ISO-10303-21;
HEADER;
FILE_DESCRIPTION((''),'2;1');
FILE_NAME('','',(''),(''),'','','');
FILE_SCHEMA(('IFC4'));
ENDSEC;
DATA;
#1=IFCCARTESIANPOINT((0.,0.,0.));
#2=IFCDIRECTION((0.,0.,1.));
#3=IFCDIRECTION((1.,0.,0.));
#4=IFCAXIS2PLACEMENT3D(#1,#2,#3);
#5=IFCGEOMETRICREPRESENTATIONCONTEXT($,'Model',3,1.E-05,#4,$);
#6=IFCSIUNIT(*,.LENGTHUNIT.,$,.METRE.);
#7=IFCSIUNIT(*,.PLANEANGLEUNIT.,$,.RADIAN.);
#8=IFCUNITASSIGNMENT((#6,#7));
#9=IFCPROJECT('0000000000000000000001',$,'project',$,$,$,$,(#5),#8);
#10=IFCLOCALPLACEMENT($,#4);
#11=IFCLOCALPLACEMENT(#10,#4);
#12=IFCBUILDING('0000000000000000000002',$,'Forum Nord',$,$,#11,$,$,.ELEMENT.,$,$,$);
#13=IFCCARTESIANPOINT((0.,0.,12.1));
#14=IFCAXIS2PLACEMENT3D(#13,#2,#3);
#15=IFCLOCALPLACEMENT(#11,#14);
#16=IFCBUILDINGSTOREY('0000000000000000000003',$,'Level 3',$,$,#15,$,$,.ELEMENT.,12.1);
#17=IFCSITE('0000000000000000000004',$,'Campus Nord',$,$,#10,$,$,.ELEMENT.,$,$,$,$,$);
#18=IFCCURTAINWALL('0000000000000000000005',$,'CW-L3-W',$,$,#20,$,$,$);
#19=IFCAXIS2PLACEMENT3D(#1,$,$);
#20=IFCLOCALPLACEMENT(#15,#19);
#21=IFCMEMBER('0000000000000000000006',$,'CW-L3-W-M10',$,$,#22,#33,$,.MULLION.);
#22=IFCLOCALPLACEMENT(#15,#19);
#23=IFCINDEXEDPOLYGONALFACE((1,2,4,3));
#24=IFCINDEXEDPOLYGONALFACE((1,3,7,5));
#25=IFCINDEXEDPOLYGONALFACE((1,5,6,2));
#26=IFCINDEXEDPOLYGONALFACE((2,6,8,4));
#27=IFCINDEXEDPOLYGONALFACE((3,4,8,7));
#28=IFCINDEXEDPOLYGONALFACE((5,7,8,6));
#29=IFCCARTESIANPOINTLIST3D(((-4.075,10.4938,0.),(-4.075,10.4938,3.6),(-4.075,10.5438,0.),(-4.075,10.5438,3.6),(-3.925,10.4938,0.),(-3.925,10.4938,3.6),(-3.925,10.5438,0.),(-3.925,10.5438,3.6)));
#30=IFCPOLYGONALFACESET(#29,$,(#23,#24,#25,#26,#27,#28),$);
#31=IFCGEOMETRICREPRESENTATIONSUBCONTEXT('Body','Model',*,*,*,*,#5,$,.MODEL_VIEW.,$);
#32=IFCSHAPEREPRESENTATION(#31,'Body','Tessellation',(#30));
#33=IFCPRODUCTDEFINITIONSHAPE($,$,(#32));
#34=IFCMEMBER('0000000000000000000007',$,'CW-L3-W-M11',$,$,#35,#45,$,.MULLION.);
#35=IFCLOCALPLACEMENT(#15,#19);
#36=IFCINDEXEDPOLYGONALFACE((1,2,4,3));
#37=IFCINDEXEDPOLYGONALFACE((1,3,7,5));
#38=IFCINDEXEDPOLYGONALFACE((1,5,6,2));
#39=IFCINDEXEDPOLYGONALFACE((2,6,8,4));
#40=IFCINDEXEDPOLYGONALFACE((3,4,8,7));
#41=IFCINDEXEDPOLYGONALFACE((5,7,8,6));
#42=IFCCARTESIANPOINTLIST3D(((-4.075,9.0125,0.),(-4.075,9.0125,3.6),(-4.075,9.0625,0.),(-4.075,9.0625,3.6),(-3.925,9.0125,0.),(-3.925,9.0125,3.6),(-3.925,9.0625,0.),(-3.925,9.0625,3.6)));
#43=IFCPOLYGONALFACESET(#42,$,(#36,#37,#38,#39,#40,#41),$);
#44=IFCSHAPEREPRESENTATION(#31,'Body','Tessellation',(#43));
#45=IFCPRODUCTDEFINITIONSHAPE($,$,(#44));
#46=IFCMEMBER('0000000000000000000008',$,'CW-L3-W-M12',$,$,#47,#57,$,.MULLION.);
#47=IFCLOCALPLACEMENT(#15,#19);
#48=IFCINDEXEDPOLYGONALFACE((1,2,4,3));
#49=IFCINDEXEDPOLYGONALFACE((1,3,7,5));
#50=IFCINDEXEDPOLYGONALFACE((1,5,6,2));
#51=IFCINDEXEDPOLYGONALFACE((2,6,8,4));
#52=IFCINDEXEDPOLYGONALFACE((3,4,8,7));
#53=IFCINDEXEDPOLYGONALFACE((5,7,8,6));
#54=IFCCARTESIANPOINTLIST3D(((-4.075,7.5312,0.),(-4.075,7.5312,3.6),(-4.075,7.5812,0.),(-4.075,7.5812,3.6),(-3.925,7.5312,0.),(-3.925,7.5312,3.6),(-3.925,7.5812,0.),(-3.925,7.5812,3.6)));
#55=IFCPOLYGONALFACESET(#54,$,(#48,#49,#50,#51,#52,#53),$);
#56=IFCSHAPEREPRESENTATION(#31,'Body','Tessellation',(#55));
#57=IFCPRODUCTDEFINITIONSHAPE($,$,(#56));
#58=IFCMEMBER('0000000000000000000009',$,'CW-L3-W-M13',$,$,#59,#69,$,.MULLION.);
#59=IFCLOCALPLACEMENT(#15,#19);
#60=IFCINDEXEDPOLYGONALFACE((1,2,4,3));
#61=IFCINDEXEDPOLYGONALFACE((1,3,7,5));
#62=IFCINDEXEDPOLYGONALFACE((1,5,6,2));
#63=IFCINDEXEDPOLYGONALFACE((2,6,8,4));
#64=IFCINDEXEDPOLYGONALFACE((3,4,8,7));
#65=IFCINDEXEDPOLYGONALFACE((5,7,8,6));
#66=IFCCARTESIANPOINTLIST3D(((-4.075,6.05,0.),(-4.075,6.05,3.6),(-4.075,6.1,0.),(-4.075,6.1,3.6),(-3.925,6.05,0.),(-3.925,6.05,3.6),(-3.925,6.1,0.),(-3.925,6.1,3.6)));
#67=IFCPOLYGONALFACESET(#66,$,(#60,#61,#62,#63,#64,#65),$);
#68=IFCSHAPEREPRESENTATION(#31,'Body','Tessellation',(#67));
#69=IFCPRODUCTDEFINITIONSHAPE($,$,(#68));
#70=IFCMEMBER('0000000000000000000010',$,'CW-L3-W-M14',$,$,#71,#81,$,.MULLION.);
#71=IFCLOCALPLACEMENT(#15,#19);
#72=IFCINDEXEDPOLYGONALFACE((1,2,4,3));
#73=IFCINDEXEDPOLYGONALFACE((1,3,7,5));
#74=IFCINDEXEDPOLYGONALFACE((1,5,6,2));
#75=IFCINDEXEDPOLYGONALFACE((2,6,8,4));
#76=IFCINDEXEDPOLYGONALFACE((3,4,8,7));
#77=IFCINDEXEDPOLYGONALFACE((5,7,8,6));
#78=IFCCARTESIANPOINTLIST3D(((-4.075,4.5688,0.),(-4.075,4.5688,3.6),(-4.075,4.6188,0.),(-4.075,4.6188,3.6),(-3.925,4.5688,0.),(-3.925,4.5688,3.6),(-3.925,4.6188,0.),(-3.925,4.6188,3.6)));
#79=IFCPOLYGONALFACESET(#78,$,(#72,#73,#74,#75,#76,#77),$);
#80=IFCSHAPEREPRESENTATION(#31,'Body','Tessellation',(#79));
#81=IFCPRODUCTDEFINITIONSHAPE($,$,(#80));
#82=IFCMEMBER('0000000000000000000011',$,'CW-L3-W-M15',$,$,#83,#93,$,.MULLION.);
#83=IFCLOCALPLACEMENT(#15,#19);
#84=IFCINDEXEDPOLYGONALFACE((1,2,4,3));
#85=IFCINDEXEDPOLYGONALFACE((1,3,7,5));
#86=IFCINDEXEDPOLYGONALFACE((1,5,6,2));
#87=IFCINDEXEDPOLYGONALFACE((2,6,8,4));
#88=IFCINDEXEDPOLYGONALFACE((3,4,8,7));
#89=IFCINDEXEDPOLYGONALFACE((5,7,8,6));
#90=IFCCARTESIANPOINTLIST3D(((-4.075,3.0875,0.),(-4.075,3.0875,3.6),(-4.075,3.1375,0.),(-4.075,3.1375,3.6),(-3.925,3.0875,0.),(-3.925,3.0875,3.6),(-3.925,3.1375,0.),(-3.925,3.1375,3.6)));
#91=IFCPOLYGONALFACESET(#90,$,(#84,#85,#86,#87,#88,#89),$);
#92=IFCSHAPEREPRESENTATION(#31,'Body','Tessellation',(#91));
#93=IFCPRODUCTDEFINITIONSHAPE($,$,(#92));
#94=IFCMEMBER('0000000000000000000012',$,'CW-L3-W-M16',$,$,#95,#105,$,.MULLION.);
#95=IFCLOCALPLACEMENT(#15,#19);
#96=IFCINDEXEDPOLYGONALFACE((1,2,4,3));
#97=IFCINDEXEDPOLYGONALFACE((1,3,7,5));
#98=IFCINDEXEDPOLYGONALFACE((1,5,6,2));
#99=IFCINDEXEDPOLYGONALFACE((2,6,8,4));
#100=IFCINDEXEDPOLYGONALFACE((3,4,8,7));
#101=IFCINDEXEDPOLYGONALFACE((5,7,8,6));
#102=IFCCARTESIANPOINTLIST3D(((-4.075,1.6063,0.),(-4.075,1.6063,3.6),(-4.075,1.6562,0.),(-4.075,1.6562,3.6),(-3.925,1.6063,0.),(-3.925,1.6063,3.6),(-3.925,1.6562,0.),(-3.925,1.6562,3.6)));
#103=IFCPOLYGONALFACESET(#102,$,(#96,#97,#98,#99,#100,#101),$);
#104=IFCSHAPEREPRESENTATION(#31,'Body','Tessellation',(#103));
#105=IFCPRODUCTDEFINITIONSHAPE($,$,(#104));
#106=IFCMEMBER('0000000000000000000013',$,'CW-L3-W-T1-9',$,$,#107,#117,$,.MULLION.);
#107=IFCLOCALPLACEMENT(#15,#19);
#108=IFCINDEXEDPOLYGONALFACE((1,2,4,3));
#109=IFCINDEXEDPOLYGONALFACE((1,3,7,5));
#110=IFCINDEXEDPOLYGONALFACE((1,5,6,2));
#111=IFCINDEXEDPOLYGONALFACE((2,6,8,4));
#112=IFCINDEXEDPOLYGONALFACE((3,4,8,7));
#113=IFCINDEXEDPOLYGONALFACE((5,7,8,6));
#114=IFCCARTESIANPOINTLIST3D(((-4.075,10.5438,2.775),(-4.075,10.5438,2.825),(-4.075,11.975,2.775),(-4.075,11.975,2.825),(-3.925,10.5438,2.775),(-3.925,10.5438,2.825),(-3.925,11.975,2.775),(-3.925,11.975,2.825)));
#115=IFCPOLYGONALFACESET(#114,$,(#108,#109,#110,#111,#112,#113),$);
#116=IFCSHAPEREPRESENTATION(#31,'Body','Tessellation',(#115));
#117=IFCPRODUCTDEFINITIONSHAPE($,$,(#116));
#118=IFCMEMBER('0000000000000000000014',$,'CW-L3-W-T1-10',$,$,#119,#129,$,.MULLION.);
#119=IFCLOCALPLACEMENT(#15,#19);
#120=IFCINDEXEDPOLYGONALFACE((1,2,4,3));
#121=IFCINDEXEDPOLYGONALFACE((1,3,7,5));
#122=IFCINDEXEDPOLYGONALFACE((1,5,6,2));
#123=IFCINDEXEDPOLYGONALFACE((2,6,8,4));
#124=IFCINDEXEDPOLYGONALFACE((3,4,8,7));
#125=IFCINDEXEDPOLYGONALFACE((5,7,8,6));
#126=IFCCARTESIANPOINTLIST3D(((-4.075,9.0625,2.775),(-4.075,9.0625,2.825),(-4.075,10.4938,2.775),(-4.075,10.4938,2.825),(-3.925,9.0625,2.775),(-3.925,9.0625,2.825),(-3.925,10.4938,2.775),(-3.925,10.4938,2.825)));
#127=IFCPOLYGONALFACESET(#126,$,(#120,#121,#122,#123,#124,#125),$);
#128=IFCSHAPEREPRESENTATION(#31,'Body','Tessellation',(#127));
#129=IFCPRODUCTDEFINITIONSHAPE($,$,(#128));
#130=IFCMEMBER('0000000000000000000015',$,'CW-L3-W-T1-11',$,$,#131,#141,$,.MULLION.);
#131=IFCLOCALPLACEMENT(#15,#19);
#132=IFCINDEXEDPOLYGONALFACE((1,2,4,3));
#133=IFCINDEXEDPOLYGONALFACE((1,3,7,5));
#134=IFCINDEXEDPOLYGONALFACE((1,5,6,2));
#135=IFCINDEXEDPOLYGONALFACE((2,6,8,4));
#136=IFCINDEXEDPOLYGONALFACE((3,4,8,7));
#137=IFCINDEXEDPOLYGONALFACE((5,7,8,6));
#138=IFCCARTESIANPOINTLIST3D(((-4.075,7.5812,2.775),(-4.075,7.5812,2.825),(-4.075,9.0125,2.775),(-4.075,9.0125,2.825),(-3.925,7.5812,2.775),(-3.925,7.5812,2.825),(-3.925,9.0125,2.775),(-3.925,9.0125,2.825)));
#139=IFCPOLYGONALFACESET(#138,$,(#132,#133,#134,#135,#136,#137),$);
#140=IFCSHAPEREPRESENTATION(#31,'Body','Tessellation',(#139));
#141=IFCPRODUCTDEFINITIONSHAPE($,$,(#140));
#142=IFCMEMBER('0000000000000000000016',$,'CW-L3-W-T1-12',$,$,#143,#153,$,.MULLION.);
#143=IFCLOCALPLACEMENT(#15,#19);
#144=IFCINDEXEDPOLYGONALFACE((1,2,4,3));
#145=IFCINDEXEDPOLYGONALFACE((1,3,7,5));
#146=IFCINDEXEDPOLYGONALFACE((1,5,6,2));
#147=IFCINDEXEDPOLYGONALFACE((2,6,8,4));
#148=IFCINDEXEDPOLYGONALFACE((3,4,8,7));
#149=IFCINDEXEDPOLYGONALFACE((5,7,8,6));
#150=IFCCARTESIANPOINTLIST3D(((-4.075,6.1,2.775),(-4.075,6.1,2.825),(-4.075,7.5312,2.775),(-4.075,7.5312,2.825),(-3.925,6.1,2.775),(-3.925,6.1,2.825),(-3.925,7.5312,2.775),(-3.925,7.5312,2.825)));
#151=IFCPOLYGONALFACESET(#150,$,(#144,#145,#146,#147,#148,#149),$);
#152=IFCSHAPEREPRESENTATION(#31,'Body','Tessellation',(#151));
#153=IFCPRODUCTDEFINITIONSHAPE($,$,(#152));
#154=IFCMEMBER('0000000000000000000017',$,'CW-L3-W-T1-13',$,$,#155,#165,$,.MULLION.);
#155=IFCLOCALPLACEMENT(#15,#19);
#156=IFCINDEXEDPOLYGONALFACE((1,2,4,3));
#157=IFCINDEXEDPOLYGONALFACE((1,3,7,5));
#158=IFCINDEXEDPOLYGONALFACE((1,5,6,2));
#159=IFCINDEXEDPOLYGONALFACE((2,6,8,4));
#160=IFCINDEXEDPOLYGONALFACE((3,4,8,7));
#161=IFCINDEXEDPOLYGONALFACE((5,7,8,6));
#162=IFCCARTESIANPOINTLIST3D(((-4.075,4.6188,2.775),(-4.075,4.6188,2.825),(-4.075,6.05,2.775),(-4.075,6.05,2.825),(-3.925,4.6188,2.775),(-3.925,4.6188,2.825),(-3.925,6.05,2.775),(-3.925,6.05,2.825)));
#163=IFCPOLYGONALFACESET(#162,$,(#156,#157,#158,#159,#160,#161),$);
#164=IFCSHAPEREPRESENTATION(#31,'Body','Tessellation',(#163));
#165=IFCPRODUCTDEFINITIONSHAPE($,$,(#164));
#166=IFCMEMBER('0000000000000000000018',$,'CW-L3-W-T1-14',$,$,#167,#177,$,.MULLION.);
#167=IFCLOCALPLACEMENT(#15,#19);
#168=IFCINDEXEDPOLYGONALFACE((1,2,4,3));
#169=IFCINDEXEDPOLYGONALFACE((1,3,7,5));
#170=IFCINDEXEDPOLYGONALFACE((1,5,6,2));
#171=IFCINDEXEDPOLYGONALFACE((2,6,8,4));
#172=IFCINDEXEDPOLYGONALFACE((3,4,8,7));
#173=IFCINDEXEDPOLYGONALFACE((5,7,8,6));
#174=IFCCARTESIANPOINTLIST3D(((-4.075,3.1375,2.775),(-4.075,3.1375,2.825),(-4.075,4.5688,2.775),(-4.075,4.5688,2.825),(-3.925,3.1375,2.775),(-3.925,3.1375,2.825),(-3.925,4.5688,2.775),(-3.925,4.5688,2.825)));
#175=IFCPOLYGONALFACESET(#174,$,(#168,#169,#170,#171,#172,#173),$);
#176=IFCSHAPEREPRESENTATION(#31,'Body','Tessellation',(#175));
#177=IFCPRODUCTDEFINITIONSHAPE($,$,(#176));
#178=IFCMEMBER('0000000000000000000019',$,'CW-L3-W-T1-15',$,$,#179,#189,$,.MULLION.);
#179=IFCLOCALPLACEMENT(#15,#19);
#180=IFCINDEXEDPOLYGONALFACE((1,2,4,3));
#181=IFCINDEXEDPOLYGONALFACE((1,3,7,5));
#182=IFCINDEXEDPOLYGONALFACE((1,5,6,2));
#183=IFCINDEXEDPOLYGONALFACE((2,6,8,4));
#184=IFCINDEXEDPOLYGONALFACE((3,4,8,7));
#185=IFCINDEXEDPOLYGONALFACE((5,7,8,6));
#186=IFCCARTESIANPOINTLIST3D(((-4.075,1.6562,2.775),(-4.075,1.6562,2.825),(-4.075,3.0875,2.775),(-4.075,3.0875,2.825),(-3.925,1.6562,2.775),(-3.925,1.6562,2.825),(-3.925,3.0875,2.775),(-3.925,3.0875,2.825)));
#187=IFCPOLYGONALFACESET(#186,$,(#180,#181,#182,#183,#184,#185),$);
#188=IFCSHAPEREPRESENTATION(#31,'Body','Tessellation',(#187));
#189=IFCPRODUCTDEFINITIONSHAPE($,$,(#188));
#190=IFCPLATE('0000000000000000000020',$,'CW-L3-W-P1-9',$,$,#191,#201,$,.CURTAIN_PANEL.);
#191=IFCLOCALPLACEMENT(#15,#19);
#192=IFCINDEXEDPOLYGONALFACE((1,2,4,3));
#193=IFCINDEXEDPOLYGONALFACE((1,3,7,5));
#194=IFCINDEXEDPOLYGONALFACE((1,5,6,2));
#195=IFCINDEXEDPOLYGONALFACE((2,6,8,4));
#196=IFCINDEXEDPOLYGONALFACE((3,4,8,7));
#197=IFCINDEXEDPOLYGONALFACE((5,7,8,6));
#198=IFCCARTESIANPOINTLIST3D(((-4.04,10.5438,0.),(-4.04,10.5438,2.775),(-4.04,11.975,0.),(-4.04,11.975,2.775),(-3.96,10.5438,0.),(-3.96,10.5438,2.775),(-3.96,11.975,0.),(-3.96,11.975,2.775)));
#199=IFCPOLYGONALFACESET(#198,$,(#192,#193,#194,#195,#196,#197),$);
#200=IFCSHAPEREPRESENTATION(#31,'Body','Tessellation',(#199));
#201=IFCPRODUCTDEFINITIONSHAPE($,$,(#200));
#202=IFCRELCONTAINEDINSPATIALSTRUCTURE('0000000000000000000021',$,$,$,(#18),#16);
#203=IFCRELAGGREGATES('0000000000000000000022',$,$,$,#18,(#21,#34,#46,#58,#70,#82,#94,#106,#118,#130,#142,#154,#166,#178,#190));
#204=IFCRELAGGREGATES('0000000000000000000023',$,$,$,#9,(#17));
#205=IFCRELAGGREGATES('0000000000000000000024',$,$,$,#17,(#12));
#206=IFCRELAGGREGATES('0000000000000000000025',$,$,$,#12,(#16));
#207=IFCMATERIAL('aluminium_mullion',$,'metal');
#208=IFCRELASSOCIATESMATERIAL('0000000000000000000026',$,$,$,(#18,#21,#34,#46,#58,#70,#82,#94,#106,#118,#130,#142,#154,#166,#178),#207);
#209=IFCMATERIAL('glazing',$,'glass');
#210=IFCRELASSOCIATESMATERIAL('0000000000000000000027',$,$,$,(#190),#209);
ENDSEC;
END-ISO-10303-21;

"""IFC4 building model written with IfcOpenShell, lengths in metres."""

from ifc_helpers import new_model, si_unit, frame, frame_2d, origin_with_axes, origin_2d_with_axis, place, context, subcontext, project, spatial, rectangle, extrude, material, element, aggregate, save


model = new_model("IFC4")

# Units and contexts
model_context = context("Model", 3, precision=1e-05, world=origin_with_axes())
body_context = subcontext(model_context, "Body", "Model", "MODEL_VIEW")
ifc_project = project(units=[si_unit("LENGTHUNIT", "METRE"), si_unit("PLANEANGLEUNIT", "RADIAN")], contexts=[model_context])

# Site, building, storey
site_placement = place(None, origin_with_axes())
site = spatial("IfcSite", under=ifc_project, at=site_placement, Name="Campus Nord", CompositionType="ELEMENT")
building_placement = place(site_placement, origin_with_axes())
building = spatial("IfcBuilding", under=site, at=building_placement, Name="Forum Nord", CompositionType="ELEMENT")
storey_placement = place(building_placement, frame((0.0, 0.0, 12.1), z_axis=(0.0, 0.0, 1.0), x_axis=(1.0, 0.0, 0.0)))
storey = spatial("IfcBuildingStorey", under=building, at=storey_placement, Name="Level 3", CompositionType="ELEMENT", Elevation=12.1)

# Curtain wall, members, plate
ifc_material_1 = material(Name="aluminium_mullion", Category="metal")
curtain_wall_placement = place(storey_placement, origin_with_axes())
curtain_wall = element("IfcCurtainWall", 1, at=curtain_wall_placement, inside=storey, material=ifc_material_1, Name="CW-L3-W")
member_1_placement = place(storey_placement, frame((-4.0, 10.5188, 0.0), z_axis=(0.0, 0.0, 1.0), x_axis=(0.0, -1.0, 0.0)))
member_1 = element("IfcMember", 2, at=member_1_placement, material=ifc_material_1, Name="CW-L3-W-M10", PredefinedType="MULLION", context=body_context, shape_type="SweptSolid", body=[
    extrude(rectangle(XDim=0.05, YDim=0.15, at=origin_2d_with_axis()), origin_with_axes(), (0.0, 0.0, 1.0), 3.6),
])
member_2_placement = place(storey_placement, frame((-4.0, 9.0375, 0.0), z_axis=(0.0, 0.0, 1.0), x_axis=(0.0, -1.0, 0.0)))
member_2 = element("IfcMember", 3, at=member_2_placement, material=ifc_material_1, Name="CW-L3-W-M11", PredefinedType="MULLION", context=body_context, shape_type="SweptSolid", body=[
    extrude(rectangle(XDim=0.05, YDim=0.15, at=origin_2d_with_axis()), origin_with_axes(), (0.0, 0.0, 1.0), 3.6),
])
member_3_placement = place(storey_placement, frame((-4.0, 7.5563, 0.0), z_axis=(0.0, 0.0, 1.0), x_axis=(0.0, -1.0, 0.0)))
member_3 = element("IfcMember", 4, at=member_3_placement, material=ifc_material_1, Name="CW-L3-W-M12", PredefinedType="MULLION", context=body_context, shape_type="SweptSolid", body=[
    extrude(rectangle(XDim=0.05, YDim=0.15, at=origin_2d_with_axis()), origin_with_axes(), (0.0, 0.0, 1.0), 3.6),
])
member_4_placement = place(storey_placement, frame((-4.0, 6.075, 0.0), z_axis=(0.0, 0.0, 1.0), x_axis=(0.0, -1.0, 0.0)))
member_4 = element("IfcMember", 5, at=member_4_placement, material=ifc_material_1, Name="CW-L3-W-M13", PredefinedType="MULLION", context=body_context, shape_type="SweptSolid", body=[
    extrude(rectangle(XDim=0.05, YDim=0.15, at=origin_2d_with_axis()), origin_with_axes(), (0.0, 0.0, 1.0), 3.6),
])
member_5_placement = place(storey_placement, frame((-4.0, 4.5938, 0.0), z_axis=(0.0, 0.0, 1.0), x_axis=(0.0, -1.0, 0.0)))
member_5 = element("IfcMember", 6, at=member_5_placement, material=ifc_material_1, Name="CW-L3-W-M14", PredefinedType="MULLION", context=body_context, shape_type="SweptSolid", body=[
    extrude(rectangle(XDim=0.05, YDim=0.15, at=origin_2d_with_axis()), origin_with_axes(), (0.0, 0.0, 1.0), 3.6),
])
member_6_placement = place(storey_placement, frame((-4.0, 3.1125, 0.0), z_axis=(0.0, 0.0, 1.0), x_axis=(0.0, -1.0, 0.0)))
member_6 = element("IfcMember", 7, at=member_6_placement, material=ifc_material_1, Name="CW-L3-W-M15", PredefinedType="MULLION", context=body_context, shape_type="SweptSolid", body=[
    extrude(rectangle(XDim=0.05, YDim=0.15, at=origin_2d_with_axis()), origin_with_axes(), (0.0, 0.0, 1.0), 3.6),
])
member_7_placement = place(storey_placement, frame((-4.0, 1.6313, 0.0), z_axis=(0.0, 0.0, 1.0), x_axis=(0.0, -1.0, 0.0)))
member_7 = element("IfcMember", 8, at=member_7_placement, material=ifc_material_1, Name="CW-L3-W-M16", PredefinedType="MULLION", context=body_context, shape_type="SweptSolid", body=[
    extrude(rectangle(XDim=0.05, YDim=0.15, at=origin_2d_with_axis()), origin_with_axes(), (0.0, 0.0, 1.0), 3.6),
])
member_8_placement = place(storey_placement, frame((-4.0, 11.975, 2.8), z_axis=(0.0, -1.0, 0.0), x_axis=(1.0, 0.0, 0.0)))
member_8 = element("IfcMember", 9, at=member_8_placement, material=ifc_material_1, Name="CW-L3-W-T1-9", PredefinedType="MULLION", context=body_context, shape_type="SweptSolid", body=[
    extrude(rectangle(XDim=0.15, YDim=0.05, at=origin_2d_with_axis()), origin_with_axes(), (0.0, 0.0, 1.0), 1.4312),
])
member_9_placement = place(storey_placement, frame((-4.0, 10.4938, 2.8), z_axis=(0.0, -1.0, 0.0), x_axis=(1.0, 0.0, 0.0)))
member_9 = element("IfcMember", 10, at=member_9_placement, material=ifc_material_1, Name="CW-L3-W-T1-10", PredefinedType="MULLION", context=body_context, shape_type="SweptSolid", body=[
    extrude(rectangle(XDim=0.15, YDim=0.05, at=origin_2d_with_axis()), origin_with_axes(), (0.0, 0.0, 1.0), 1.4312),
])
member_10_placement = place(storey_placement, frame((-4.0, 9.0125, 2.8), z_axis=(0.0, -1.0, 0.0), x_axis=(1.0, 0.0, 0.0)))
member_10 = element("IfcMember", 11, at=member_10_placement, material=ifc_material_1, Name="CW-L3-W-T1-11", PredefinedType="MULLION", context=body_context, shape_type="SweptSolid", body=[
    extrude(rectangle(XDim=0.15, YDim=0.05, at=origin_2d_with_axis()), origin_with_axes(), (0.0, 0.0, 1.0), 1.4312),
])
member_11_placement = place(storey_placement, frame((-4.0, 7.5312, 2.8), z_axis=(0.0, -1.0, 0.0), x_axis=(1.0, 0.0, 0.0)))
member_11 = element("IfcMember", 12, at=member_11_placement, material=ifc_material_1, Name="CW-L3-W-T1-12", PredefinedType="MULLION", context=body_context, shape_type="SweptSolid", body=[
    extrude(rectangle(XDim=0.15, YDim=0.05, at=origin_2d_with_axis()), origin_with_axes(), (0.0, 0.0, 1.0), 1.4312),
])
member_12_placement = place(storey_placement, frame((-4.0, 6.05, 2.8), z_axis=(0.0, -1.0, 0.0), x_axis=(1.0, 0.0, 0.0)))
member_12 = element("IfcMember", 13, at=member_12_placement, material=ifc_material_1, Name="CW-L3-W-T1-13", PredefinedType="MULLION", context=body_context, shape_type="SweptSolid", body=[
    extrude(rectangle(XDim=0.15, YDim=0.05, at=origin_2d_with_axis()), origin_with_axes(), (0.0, 0.0, 1.0), 1.4312),
])
member_13_placement = place(storey_placement, frame((-4.0, 4.5687, 2.8), z_axis=(0.0, -1.0, 0.0), x_axis=(1.0, 0.0, 0.0)))
member_13 = element("IfcMember", 14, at=member_13_placement, material=ifc_material_1, Name="CW-L3-W-T1-14", PredefinedType="MULLION", context=body_context, shape_type="SweptSolid", body=[
    extrude(rectangle(XDim=0.15, YDim=0.05, at=origin_2d_with_axis()), origin_with_axes(), (0.0, 0.0, 1.0), 1.4312),
])
member_14_placement = place(storey_placement, frame((-4.0, 3.0875, 2.8), z_axis=(0.0, -1.0, 0.0), x_axis=(1.0, 0.0, 0.0)))
member_14 = element("IfcMember", 15, at=member_14_placement, material=ifc_material_1, Name="CW-L3-W-T1-15", PredefinedType="MULLION", context=body_context, shape_type="SweptSolid", body=[
    extrude(rectangle(XDim=0.15, YDim=0.05, at=origin_2d_with_axis()), origin_with_axes(), (0.0, 0.0, 1.0), 1.4312),
])
ifc_material_2 = material(Name="glazing", Category="glass")
plate_1_placement = place(storey_placement, frame((-4.0, 11.975, 0.0), z_axis=(0.0, 0.0, 1.0), x_axis=(0.0, -1.0, 0.0)))
plate_1 = element("IfcPlate", 16, at=plate_1_placement, material=ifc_material_2, Name="CW-L3-W-P1-9", PredefinedType="CURTAIN_PANEL", context=body_context, shape_type="SweptSolid", body=[
    extrude(rectangle(XDim=1.4312, YDim=0.08, at=frame_2d((0.7156, 0.0), x_axis=(1.0, 0.0))), origin_with_axes(), (0.0, 0.0, 1.0), 2.775),
])
aggregate(curtain_wall, [member_1, member_2, member_3, member_4, member_5, member_6, member_7, member_8, member_9, member_10, member_11, member_12, member_13, member_14, plate_1])

save(model, "model.ifc")
